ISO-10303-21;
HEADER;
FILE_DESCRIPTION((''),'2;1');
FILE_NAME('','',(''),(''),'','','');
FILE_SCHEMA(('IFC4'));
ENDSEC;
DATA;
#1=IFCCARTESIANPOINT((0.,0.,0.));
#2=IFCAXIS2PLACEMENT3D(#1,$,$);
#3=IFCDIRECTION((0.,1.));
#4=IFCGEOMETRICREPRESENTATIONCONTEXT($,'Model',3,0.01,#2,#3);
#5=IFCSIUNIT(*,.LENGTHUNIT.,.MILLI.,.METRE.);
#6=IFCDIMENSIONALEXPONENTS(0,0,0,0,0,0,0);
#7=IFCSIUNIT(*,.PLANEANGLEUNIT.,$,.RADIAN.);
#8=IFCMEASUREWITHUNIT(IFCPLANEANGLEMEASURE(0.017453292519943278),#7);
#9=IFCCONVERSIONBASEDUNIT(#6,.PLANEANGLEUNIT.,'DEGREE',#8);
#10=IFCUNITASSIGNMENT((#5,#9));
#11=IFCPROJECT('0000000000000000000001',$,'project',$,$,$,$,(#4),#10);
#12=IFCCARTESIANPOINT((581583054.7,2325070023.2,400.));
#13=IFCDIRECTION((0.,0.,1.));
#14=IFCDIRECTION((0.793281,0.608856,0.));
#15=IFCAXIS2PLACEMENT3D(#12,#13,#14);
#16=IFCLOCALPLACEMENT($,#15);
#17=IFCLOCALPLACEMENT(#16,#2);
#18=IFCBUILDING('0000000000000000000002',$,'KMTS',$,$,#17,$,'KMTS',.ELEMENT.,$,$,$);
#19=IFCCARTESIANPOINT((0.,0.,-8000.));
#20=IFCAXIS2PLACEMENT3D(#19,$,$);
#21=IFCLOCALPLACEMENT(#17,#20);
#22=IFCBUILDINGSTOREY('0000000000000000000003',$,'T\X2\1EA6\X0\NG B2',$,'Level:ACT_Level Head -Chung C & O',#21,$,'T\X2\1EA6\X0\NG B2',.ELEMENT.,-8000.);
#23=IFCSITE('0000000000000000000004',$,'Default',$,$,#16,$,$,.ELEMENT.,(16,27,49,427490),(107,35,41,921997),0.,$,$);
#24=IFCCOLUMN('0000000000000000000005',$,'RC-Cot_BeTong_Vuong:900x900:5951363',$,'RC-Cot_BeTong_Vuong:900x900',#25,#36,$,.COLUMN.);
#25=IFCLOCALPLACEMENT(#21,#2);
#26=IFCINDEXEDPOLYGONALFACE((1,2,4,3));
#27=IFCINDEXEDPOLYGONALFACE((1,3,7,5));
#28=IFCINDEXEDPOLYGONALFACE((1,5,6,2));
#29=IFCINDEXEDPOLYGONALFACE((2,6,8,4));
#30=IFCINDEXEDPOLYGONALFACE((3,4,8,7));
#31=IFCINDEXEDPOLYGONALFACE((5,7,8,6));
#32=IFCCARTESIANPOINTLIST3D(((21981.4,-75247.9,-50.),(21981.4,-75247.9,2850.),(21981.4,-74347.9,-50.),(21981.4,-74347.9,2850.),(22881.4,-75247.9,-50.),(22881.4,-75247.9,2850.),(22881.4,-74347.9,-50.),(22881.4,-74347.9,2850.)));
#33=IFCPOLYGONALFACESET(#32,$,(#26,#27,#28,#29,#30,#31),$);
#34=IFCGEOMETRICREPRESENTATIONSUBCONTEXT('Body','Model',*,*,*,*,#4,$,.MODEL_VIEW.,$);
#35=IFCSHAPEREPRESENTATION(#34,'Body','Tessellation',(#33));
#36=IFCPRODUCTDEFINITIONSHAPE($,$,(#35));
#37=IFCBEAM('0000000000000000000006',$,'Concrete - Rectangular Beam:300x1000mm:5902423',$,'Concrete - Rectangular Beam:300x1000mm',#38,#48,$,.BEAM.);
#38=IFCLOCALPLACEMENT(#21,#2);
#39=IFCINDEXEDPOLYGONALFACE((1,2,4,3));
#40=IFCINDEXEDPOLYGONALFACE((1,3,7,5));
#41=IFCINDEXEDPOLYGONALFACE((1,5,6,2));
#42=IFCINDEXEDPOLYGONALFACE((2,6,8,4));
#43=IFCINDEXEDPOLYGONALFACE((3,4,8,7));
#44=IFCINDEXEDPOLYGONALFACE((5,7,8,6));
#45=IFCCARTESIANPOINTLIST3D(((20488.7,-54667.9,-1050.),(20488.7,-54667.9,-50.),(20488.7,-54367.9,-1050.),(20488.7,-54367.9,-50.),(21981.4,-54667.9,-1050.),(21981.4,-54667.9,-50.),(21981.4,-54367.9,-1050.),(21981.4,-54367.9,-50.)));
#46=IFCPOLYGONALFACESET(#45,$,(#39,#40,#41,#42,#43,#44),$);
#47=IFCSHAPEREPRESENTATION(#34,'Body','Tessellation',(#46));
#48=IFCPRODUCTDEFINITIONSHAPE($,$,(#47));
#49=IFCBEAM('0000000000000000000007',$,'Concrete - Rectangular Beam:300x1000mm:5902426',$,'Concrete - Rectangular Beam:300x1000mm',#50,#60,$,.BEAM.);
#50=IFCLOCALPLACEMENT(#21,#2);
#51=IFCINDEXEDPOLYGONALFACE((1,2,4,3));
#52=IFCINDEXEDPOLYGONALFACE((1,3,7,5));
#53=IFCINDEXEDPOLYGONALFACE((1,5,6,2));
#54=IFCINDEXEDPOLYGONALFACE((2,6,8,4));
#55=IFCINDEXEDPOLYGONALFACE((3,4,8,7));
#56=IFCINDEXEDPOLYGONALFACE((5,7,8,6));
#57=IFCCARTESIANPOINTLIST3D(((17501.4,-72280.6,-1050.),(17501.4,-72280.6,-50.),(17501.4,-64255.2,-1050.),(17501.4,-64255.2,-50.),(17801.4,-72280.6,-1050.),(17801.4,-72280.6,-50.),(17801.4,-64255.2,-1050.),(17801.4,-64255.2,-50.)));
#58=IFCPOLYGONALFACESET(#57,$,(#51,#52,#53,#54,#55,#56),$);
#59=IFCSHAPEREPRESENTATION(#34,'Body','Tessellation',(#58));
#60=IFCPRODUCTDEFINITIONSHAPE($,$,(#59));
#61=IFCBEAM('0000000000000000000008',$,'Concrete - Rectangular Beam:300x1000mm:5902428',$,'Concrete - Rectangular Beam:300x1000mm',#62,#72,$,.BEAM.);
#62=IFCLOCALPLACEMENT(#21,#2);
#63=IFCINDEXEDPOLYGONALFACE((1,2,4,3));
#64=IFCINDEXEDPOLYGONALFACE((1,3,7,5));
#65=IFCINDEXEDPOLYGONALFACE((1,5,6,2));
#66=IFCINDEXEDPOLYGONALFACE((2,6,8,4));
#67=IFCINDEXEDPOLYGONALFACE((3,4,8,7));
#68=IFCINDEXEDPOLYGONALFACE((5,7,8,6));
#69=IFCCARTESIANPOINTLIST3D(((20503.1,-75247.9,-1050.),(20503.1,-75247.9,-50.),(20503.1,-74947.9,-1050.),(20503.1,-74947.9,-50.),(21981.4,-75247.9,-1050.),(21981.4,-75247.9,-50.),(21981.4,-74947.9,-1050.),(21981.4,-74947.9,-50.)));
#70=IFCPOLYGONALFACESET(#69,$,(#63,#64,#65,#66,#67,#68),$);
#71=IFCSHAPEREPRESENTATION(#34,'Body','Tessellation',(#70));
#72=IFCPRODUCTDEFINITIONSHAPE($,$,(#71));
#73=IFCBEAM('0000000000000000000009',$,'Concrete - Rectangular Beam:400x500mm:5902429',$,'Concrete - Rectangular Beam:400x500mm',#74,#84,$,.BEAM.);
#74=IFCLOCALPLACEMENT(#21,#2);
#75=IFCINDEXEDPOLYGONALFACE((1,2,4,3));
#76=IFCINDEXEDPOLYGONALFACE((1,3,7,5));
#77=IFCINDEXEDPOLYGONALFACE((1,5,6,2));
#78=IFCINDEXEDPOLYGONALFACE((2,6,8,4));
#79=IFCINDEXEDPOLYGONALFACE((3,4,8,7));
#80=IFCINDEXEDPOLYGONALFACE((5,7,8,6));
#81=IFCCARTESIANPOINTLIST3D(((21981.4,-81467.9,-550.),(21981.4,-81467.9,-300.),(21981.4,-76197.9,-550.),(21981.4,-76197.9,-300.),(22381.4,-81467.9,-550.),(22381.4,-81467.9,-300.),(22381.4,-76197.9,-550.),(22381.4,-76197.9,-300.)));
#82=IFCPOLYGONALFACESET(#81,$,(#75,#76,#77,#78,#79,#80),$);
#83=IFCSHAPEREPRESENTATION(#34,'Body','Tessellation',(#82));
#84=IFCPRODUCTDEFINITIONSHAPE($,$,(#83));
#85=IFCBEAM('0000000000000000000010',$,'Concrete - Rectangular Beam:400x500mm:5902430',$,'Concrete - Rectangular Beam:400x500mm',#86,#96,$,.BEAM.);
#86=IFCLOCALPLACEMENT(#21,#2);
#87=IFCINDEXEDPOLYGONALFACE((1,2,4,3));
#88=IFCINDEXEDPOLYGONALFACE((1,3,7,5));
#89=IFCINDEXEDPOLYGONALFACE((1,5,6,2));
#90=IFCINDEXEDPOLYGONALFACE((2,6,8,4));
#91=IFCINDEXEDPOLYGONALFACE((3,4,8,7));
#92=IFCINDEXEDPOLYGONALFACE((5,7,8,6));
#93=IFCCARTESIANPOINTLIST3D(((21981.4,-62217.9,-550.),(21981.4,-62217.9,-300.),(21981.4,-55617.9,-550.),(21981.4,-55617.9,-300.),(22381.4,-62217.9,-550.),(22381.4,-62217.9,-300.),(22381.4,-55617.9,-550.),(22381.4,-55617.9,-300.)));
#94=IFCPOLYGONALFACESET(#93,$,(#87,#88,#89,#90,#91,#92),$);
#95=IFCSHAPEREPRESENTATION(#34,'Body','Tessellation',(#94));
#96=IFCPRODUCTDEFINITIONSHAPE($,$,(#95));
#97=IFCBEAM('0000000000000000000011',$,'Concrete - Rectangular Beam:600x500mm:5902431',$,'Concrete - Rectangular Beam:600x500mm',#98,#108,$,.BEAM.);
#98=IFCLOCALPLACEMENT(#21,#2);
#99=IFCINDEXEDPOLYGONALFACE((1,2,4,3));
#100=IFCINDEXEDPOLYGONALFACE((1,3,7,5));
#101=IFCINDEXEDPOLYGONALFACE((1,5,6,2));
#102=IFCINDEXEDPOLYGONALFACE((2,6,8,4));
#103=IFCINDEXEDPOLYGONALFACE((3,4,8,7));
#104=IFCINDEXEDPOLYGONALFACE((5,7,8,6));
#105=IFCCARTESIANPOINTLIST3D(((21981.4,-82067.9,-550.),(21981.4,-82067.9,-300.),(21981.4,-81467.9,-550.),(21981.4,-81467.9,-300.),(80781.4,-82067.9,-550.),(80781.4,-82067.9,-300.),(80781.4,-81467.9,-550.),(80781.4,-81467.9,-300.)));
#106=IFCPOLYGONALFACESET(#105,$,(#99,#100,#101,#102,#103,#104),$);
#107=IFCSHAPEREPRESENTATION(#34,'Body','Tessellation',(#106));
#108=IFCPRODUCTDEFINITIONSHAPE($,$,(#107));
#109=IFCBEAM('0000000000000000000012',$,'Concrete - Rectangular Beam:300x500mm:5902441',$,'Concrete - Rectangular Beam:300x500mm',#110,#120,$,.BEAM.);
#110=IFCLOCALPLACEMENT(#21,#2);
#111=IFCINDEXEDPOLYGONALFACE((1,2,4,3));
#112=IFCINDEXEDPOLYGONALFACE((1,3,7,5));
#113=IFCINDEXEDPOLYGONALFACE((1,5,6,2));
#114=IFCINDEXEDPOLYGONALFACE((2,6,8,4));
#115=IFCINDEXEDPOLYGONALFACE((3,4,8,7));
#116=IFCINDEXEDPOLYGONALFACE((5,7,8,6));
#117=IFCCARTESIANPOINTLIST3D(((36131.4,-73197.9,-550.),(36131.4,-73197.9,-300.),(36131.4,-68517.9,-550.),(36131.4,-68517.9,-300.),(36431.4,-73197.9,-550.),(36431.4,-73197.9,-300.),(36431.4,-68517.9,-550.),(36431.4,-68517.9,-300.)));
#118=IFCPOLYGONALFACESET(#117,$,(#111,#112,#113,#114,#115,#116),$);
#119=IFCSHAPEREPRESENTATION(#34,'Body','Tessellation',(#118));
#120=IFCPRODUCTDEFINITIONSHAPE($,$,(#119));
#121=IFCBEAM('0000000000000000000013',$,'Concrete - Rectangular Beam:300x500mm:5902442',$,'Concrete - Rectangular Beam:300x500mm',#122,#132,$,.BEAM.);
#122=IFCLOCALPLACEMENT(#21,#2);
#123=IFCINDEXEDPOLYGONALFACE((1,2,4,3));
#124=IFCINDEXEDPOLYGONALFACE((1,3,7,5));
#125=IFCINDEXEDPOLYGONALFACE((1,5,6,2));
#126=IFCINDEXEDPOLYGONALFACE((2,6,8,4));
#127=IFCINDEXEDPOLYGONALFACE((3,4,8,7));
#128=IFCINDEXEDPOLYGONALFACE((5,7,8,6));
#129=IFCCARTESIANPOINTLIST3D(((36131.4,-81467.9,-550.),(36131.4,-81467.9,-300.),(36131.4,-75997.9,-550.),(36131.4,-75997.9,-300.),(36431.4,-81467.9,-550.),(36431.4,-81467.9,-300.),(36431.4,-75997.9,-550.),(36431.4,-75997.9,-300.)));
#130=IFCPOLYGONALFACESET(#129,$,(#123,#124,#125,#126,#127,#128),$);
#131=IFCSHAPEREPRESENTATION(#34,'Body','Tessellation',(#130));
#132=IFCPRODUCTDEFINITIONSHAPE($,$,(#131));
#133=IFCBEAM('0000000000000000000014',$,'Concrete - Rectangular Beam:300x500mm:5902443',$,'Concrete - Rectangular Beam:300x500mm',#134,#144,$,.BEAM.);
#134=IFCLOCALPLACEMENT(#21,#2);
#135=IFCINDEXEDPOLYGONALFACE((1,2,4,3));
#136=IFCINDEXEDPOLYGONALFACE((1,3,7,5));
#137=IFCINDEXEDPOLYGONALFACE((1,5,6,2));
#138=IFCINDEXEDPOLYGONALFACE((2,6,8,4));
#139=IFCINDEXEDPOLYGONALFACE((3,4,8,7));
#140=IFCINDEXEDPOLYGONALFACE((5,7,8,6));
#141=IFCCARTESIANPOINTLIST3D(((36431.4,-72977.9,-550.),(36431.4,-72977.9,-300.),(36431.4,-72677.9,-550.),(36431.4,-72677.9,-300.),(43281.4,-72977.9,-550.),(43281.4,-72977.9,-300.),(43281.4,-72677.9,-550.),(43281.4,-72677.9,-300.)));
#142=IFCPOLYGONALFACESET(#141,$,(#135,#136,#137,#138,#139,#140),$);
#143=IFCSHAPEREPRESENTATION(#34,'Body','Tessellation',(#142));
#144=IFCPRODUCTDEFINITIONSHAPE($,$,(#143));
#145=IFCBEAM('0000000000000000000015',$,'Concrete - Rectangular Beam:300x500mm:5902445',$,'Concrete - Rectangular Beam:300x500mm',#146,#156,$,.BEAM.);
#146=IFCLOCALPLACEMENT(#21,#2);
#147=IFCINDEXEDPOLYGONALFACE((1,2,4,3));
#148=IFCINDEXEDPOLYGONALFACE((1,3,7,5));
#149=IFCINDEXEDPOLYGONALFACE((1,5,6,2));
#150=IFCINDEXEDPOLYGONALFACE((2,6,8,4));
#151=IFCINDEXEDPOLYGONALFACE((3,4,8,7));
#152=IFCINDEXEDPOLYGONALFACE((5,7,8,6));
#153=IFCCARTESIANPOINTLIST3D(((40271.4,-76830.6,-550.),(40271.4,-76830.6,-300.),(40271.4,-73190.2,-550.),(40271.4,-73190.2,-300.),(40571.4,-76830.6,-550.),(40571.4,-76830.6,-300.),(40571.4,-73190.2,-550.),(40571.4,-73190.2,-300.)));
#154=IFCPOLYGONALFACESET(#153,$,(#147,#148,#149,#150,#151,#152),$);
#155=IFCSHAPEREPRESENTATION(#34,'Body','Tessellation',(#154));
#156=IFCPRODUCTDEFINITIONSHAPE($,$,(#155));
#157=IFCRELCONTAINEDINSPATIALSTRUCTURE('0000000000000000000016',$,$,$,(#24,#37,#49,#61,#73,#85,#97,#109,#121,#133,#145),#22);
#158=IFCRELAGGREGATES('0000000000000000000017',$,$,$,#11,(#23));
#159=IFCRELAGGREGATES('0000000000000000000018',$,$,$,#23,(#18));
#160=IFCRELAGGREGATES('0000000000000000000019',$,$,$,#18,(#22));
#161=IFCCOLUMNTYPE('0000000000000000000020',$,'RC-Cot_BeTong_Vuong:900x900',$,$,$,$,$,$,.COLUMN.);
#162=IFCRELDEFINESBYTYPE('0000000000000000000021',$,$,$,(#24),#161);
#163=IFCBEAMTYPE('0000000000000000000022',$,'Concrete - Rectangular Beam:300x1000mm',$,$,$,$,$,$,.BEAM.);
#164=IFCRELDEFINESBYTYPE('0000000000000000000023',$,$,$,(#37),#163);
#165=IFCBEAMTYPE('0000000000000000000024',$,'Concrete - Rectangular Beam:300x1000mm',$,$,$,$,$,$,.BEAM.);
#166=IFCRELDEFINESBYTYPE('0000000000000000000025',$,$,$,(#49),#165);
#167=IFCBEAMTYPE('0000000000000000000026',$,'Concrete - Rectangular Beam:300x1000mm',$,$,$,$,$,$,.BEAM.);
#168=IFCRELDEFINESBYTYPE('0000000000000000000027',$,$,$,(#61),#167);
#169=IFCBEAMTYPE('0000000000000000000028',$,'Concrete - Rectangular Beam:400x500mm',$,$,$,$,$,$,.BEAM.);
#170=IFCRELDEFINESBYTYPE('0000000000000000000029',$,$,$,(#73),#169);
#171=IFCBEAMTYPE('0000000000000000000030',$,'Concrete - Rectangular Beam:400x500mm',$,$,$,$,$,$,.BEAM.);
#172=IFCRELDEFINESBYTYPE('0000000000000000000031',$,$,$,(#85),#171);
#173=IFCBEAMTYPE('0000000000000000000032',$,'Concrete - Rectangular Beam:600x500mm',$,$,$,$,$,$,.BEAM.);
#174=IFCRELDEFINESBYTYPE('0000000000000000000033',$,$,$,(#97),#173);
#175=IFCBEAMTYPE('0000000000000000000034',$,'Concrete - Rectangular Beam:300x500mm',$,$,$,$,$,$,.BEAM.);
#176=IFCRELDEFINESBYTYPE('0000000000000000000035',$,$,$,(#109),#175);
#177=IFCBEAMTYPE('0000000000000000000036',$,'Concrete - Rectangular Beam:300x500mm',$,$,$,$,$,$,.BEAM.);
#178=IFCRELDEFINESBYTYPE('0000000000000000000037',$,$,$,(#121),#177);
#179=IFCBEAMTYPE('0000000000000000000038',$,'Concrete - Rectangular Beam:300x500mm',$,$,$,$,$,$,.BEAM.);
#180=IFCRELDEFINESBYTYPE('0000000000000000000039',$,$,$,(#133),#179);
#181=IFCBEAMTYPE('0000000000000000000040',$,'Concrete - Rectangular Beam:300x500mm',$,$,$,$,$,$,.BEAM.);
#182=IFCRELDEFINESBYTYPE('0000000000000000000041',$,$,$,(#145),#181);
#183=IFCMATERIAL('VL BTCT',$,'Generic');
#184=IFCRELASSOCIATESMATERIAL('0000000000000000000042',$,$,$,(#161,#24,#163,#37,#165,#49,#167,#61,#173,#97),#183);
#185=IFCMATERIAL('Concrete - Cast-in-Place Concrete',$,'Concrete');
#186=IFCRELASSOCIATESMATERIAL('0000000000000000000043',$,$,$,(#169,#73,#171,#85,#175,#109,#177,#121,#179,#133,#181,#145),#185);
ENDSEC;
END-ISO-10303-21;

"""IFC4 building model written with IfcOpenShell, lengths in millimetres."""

from ifc_helpers import new_model, entity, si_unit, converted_unit, direction, frame, origin, place, context, subcontext, project, spatial, indexed_curve, outline, extrude, source, transform, mapped, material, type_object, type_shapes, element, save


model = new_model("IFC4")

# Units and contexts
model_context = context("Model", 3, precision=0.01, world=origin(), true_north=direction((0.0, 1.0)))
body_context = subcontext(model_context, "Body", "Model", "MODEL_VIEW")
ifc_project = project(units=[si_unit("LENGTHUNIT", "METRE", prefix="MILLI"), converted_unit("PLANEANGLEUNIT", "DEGREE", entity("IfcPlaneAngleMeasure", 0.017453292519943278), si_unit("PLANEANGLEUNIT", "RADIAN"), dimensions=[0, 0, 0, 0, 0, 0, 0])], contexts=[model_context])

# Site, building, storey
site_placement = place(None, frame((581583054.7, 2325070023.2, 400.0), z_axis=(0.0, 0.0, 1.0), x_axis=(0.793281, 0.608856, 0.0)))
site = spatial("IfcSite", under=ifc_project, at=site_placement, Name="Default", CompositionType="ELEMENT", RefLatitude=(16, 27, 49, 427490), RefLongitude=(107, 35, 41, 921997), RefElevation=0.0)
building_placement = place(site_placement, origin())
building = spatial("IfcBuilding", under=site, at=building_placement, Name="KMTS", LongName="KMTS", CompositionType="ELEMENT")
storey_placement = place(building_placement, frame((0.0, 0.0, -8000.0)))
storey = spatial("IfcBuildingStorey", under=building, at=storey_placement, Name="TẦNG B2", ObjectType="Level:ACT_Level Head -Chung C & O", LongName="TẦNG B2", CompositionType="ELEMENT", Elevation=-8000.0)

# Column
ifc_material_1 = material(Name="VL BTCT", Category="Generic")
column_type = type_object("IfcColumnType", Name="RC-Cot_BeTong_Vuong:900x900", PredefinedType="COLUMN", material=ifc_material_1)
shared_shape_1 = source(origin(), body_context, "Body", "SweptSolid", [
    extrude(outline(indexed_curve([(-450.0, -450.0), (450.0, -450.0), (450.0, 450.0), (-450.0, 450.0), (-450.0, -450.0)], self_intersect=False)), frame((22431.4, -74797.9, -8050.0), z_axis=(0.0, 0.0, 1.0), x_axis=(-1.0, 0.0, 0.0)), (0.0, 0.0, 1.0), 2900.0),
])
type_shapes(column_type, [shared_shape_1])
column_placement = place(storey_placement, frame((0.0, 0.0, 8000.0)))
element("IfcColumn", 1, at=column_placement, inside=storey, type_object=column_type, material=ifc_material_1, Name="RC-Cot_BeTong_Vuong:900x900:5951363", ObjectType="RC-Cot_BeTong_Vuong:900x900", PredefinedType="COLUMN", context=body_context, shape_type="MappedRepresentation", body=[
    mapped(shared_shape_1, transform((0.0, 0.0, 0.0), scale=1.0)),
])

# Beams
beam_type_1 = type_object("IfcBeamType", Name="Concrete - Rectangular Beam:300x1000mm", PredefinedType="BEAM", material=ifc_material_1)
shared_shape_2 = source(origin(), body_context, "Body", "SweptSolid", [
    extrude(outline(indexed_curve([(-500.0, -150.0), (500.0, -150.0), (500.0, 150.0), (-500.0, 150.0), (-500.0, -150.0)], self_intersect=False)), frame((21981.4, -54517.9, -8550.0), z_axis=(-1.0, 0.0, 0.0), x_axis=(0.0, 0.0, -1.0)), (0.0, 0.0, 1.0), 1492.7),
])
type_shapes(beam_type_1, [shared_shape_2])
beam_1_placement = place(storey_placement, frame((0.0, 0.0, 8000.0)))
element("IfcBeam", 2, at=beam_1_placement, inside=storey, type_object=beam_type_1, material=ifc_material_1, Name="Concrete - Rectangular Beam:300x1000mm:5902423", ObjectType="Concrete - Rectangular Beam:300x1000mm", PredefinedType="BEAM", context=body_context, shape_type="MappedRepresentation", body=[
    mapped(shared_shape_2, transform((0.0, 0.0, 0.0), scale=1.0)),
])
beam_type_2 = type_object("IfcBeamType", Name="Concrete - Rectangular Beam:300x1000mm", PredefinedType="BEAM", material=ifc_material_1)
shared_shape_3 = source(origin(), body_context, "Body", "SweptSolid", [
    extrude(outline(indexed_curve([(-150.0, -500.0), (150.0, -500.0), (150.0, 500.0), (-150.0, 500.0), (-150.0, -500.0)], self_intersect=False)), frame((17651.4, -72280.6, -8550.0), z_axis=(0.0, 1.0, 0.0), x_axis=(-1.0, 0.0, 0.0)), (0.0, 0.0, 1.0), 8025.4),
])
type_shapes(beam_type_2, [shared_shape_3])
beam_2_placement = place(storey_placement, frame((0.0, 0.0, 8000.0)))
element("IfcBeam", 3, at=beam_2_placement, inside=storey, type_object=beam_type_2, material=ifc_material_1, Name="Concrete - Rectangular Beam:300x1000mm:5902426", ObjectType="Concrete - Rectangular Beam:300x1000mm", PredefinedType="BEAM", context=body_context, shape_type="MappedRepresentation", body=[
    mapped(shared_shape_3, transform((0.0, 0.0, 0.0), scale=1.0)),
])
beam_type_3 = type_object("IfcBeamType", Name="Concrete - Rectangular Beam:300x1000mm", PredefinedType="BEAM", material=ifc_material_1)
shared_shape_4 = source(origin(), body_context, "Body", "SweptSolid", [
    extrude(outline(indexed_curve([(-500.0, -150.0), (500.0, -150.0), (500.0, 150.0), (-500.0, 150.0), (-500.0, -150.0)], self_intersect=False)), frame((21981.4, -75097.9, -8550.0), z_axis=(-1.0, 0.0, 0.0), x_axis=(0.0, 0.0, -1.0)), (0.0, 0.0, 1.0), 1478.3),
])
type_shapes(beam_type_3, [shared_shape_4])
beam_3_placement = place(storey_placement, frame((0.0, 0.0, 8000.0)))
element("IfcBeam", 4, at=beam_3_placement, inside=storey, type_object=beam_type_3, material=ifc_material_1, Name="Concrete - Rectangular Beam:300x1000mm:5902428", ObjectType="Concrete - Rectangular Beam:300x1000mm", PredefinedType="BEAM", context=body_context, shape_type="MappedRepresentation", body=[
    mapped(shared_shape_4, transform((0.0, 0.0, 0.0), scale=1.0)),
])
ifc_material_2 = material(Name="Concrete - Cast-in-Place Concrete", Category="Concrete")
beam_type_4 = type_object("IfcBeamType", Name="Concrete - Rectangular Beam:400x500mm", PredefinedType="BEAM", material=ifc_material_2)
shared_shape_5 = source(origin(), body_context, "Body", "SweptSolid", [
    extrude(outline(indexed_curve([(-200.0, -125.0), (200.0, -125.0), (200.0, 125.0), (-200.0, 125.0), (-200.0, -125.0)], self_intersect=False)), frame((22181.4, -81467.9, -8425.0), z_axis=(0.0, 1.0, 0.0), x_axis=(-1.0, 0.0, 0.0)), (0.0, 0.0, 1.0), 5270.0),
])
type_shapes(beam_type_4, [shared_shape_5])
beam_4_placement = place(storey_placement, frame((0.0, 0.0, 8000.0)))
element("IfcBeam", 5, at=beam_4_placement, inside=storey, type_object=beam_type_4, material=ifc_material_2, Name="Concrete - Rectangular Beam:400x500mm:5902429", ObjectType="Concrete - Rectangular Beam:400x500mm", PredefinedType="BEAM", context=body_context, shape_type="MappedRepresentation", body=[
    mapped(shared_shape_5, transform((0.0, 0.0, 0.0), scale=1.0)),
])
beam_type_5 = type_object("IfcBeamType", Name="Concrete - Rectangular Beam:400x500mm", PredefinedType="BEAM", material=ifc_material_2)
shared_shape_6 = source(origin(), body_context, "Body", "SweptSolid", [
    extrude(outline(indexed_curve([(-200.0, -125.0), (200.0, -125.0), (200.0, 125.0), (-200.0, 125.0), (-200.0, -125.0)], self_intersect=False)), frame((22181.4, -62217.9, -8425.0), z_axis=(0.0, 1.0, 0.0), x_axis=(-1.0, 0.0, 0.0)), (0.0, 0.0, 1.0), 6600.0),
])
type_shapes(beam_type_5, [shared_shape_6])
beam_5_placement = place(storey_placement, frame((0.0, 0.0, 8000.0)))
element("IfcBeam", 6, at=beam_5_placement, inside=storey, type_object=beam_type_5, material=ifc_material_2, Name="Concrete - Rectangular Beam:400x500mm:5902430", ObjectType="Concrete - Rectangular Beam:400x500mm", PredefinedType="BEAM", context=body_context, shape_type="MappedRepresentation", body=[
    mapped(shared_shape_6, transform((0.0, 0.0, 0.0), scale=1.0)),
])
beam_type_6 = type_object("IfcBeamType", Name="Concrete - Rectangular Beam:600x500mm", PredefinedType="BEAM", material=ifc_material_1)
shared_shape_7 = source(origin(), body_context, "Body", "SweptSolid", [
    extrude(outline(indexed_curve([(-125.0, -300.0), (125.0, -300.0), (125.0, 300.0), (-125.0, 300.0), (-125.0, -300.0)], self_intersect=False)), frame((80781.4, -81767.9, -8425.0), z_axis=(-1.0, 0.0, 0.0), x_axis=(0.0, 0.0, -1.0)), (0.0, 0.0, 1.0), 58800.0),
])
type_shapes(beam_type_6, [shared_shape_7])
beam_6_placement = place(storey_placement, frame((0.0, 0.0, 8000.0)))
element("IfcBeam", 7, at=beam_6_placement, inside=storey, type_object=beam_type_6, material=ifc_material_1, Name="Concrete - Rectangular Beam:600x500mm:5902431", ObjectType="Concrete - Rectangular Beam:600x500mm", PredefinedType="BEAM", context=body_context, shape_type="MappedRepresentation", body=[
    mapped(shared_shape_7, transform((0.0, 0.0, 0.0), scale=1.0)),
])
beam_type_7 = type_object("IfcBeamType", Name="Concrete - Rectangular Beam:300x500mm", PredefinedType="BEAM", material=ifc_material_2)
shared_shape_8 = source(origin(), body_context, "Body", "SweptSolid", [
    extrude(outline(indexed_curve([(-150.0, -125.0), (150.0, -125.0), (150.0, 125.0), (-150.0, 125.0), (-150.0, -125.0)], self_intersect=False)), frame((36281.4, -73197.9, -8425.0), z_axis=(0.0, 1.0, 0.0), x_axis=(-1.0, 0.0, 0.0)), (0.0, 0.0, 1.0), 4680.0),
])
type_shapes(beam_type_7, [shared_shape_8])
beam_7_placement = place(storey_placement, frame((0.0, 0.0, 8000.0)))
element("IfcBeam", 8, at=beam_7_placement, inside=storey, type_object=beam_type_7, material=ifc_material_2, Name="Concrete - Rectangular Beam:300x500mm:5902441", ObjectType="Concrete - Rectangular Beam:300x500mm", PredefinedType="BEAM", context=body_context, shape_type="MappedRepresentation", body=[
    mapped(shared_shape_8, transform((0.0, 0.0, 0.0), scale=1.0)),
])
beam_type_8 = type_object("IfcBeamType", Name="Concrete - Rectangular Beam:300x500mm", PredefinedType="BEAM", material=ifc_material_2)
shared_shape_9 = source(origin(), body_context, "Body", "SweptSolid", [
    extrude(outline(indexed_curve([(-150.0, -125.0), (150.0, -125.0), (150.0, 125.0), (-150.0, 125.0), (-150.0, -125.0)], self_intersect=False)), frame((36281.4, -81467.9, -8425.0), z_axis=(0.0, 1.0, 0.0), x_axis=(-1.0, 0.0, 0.0)), (0.0, 0.0, 1.0), 5470.0),
])
type_shapes(beam_type_8, [shared_shape_9])
beam_8_placement = place(storey_placement, frame((0.0, 0.0, 8000.0)))
element("IfcBeam", 9, at=beam_8_placement, inside=storey, type_object=beam_type_8, material=ifc_material_2, Name="Concrete - Rectangular Beam:300x500mm:5902442", ObjectType="Concrete - Rectangular Beam:300x500mm", PredefinedType="BEAM", context=body_context, shape_type="MappedRepresentation", body=[
    mapped(shared_shape_9, transform((0.0, 0.0, 0.0), scale=1.0)),
])
beam_type_9 = type_object("IfcBeamType", Name="Concrete - Rectangular Beam:300x500mm", PredefinedType="BEAM", material=ifc_material_2)
shared_shape_10 = source(origin(), body_context, "Body", "SweptSolid", [
    extrude(outline(indexed_curve([(-125.0, -150.0), (125.0, -150.0), (125.0, 150.0), (-125.0, 150.0), (-125.0, -150.0)], self_intersect=False)), frame((43281.4, -72827.9, -8425.0), z_axis=(-1.0, 0.0, 0.0), x_axis=(0.0, 0.0, -1.0)), (0.0, 0.0, 1.0), 6850.0),
])
type_shapes(beam_type_9, [shared_shape_10])
beam_9_placement = place(storey_placement, frame((0.0, 0.0, 8000.0)))
element("IfcBeam", 10, at=beam_9_placement, inside=storey, type_object=beam_type_9, material=ifc_material_2, Name="Concrete - Rectangular Beam:300x500mm:5902443", ObjectType="Concrete - Rectangular Beam:300x500mm", PredefinedType="BEAM", context=body_context, shape_type="MappedRepresentation", body=[
    mapped(shared_shape_10, transform((0.0, 0.0, 0.0), scale=1.0)),
])
beam_type_10 = type_object("IfcBeamType", Name="Concrete - Rectangular Beam:300x500mm", PredefinedType="BEAM", material=ifc_material_2)
shared_shape_11 = source(origin(), body_context, "Body", "SweptSolid", [
    extrude(outline(indexed_curve([(-150.0, -125.0), (150.0, -125.0), (150.0, 125.0), (-150.0, 125.0), (-150.0, -125.0)], self_intersect=False)), frame((40421.4, -73190.2, -8425.0), z_axis=(0.0, -1.0, 0.0), x_axis=(-1.0, 0.0, 0.0)), (0.0, 0.0, 1.0), 3640.4),
])
type_shapes(beam_type_10, [shared_shape_11])
beam_10_placement = place(storey_placement, frame((0.0, 0.0, 8000.0)))
element("IfcBeam", 11, at=beam_10_placement, inside=storey, type_object=beam_type_10, material=ifc_material_2, Name="Concrete - Rectangular Beam:300x500mm:5902445", ObjectType="Concrete - Rectangular Beam:300x500mm", PredefinedType="BEAM", context=body_context, shape_type="MappedRepresentation", body=[
    mapped(shared_shape_11, transform((0.0, 0.0, 0.0), scale=1.0)),
])

save(model, "model.ifc")
